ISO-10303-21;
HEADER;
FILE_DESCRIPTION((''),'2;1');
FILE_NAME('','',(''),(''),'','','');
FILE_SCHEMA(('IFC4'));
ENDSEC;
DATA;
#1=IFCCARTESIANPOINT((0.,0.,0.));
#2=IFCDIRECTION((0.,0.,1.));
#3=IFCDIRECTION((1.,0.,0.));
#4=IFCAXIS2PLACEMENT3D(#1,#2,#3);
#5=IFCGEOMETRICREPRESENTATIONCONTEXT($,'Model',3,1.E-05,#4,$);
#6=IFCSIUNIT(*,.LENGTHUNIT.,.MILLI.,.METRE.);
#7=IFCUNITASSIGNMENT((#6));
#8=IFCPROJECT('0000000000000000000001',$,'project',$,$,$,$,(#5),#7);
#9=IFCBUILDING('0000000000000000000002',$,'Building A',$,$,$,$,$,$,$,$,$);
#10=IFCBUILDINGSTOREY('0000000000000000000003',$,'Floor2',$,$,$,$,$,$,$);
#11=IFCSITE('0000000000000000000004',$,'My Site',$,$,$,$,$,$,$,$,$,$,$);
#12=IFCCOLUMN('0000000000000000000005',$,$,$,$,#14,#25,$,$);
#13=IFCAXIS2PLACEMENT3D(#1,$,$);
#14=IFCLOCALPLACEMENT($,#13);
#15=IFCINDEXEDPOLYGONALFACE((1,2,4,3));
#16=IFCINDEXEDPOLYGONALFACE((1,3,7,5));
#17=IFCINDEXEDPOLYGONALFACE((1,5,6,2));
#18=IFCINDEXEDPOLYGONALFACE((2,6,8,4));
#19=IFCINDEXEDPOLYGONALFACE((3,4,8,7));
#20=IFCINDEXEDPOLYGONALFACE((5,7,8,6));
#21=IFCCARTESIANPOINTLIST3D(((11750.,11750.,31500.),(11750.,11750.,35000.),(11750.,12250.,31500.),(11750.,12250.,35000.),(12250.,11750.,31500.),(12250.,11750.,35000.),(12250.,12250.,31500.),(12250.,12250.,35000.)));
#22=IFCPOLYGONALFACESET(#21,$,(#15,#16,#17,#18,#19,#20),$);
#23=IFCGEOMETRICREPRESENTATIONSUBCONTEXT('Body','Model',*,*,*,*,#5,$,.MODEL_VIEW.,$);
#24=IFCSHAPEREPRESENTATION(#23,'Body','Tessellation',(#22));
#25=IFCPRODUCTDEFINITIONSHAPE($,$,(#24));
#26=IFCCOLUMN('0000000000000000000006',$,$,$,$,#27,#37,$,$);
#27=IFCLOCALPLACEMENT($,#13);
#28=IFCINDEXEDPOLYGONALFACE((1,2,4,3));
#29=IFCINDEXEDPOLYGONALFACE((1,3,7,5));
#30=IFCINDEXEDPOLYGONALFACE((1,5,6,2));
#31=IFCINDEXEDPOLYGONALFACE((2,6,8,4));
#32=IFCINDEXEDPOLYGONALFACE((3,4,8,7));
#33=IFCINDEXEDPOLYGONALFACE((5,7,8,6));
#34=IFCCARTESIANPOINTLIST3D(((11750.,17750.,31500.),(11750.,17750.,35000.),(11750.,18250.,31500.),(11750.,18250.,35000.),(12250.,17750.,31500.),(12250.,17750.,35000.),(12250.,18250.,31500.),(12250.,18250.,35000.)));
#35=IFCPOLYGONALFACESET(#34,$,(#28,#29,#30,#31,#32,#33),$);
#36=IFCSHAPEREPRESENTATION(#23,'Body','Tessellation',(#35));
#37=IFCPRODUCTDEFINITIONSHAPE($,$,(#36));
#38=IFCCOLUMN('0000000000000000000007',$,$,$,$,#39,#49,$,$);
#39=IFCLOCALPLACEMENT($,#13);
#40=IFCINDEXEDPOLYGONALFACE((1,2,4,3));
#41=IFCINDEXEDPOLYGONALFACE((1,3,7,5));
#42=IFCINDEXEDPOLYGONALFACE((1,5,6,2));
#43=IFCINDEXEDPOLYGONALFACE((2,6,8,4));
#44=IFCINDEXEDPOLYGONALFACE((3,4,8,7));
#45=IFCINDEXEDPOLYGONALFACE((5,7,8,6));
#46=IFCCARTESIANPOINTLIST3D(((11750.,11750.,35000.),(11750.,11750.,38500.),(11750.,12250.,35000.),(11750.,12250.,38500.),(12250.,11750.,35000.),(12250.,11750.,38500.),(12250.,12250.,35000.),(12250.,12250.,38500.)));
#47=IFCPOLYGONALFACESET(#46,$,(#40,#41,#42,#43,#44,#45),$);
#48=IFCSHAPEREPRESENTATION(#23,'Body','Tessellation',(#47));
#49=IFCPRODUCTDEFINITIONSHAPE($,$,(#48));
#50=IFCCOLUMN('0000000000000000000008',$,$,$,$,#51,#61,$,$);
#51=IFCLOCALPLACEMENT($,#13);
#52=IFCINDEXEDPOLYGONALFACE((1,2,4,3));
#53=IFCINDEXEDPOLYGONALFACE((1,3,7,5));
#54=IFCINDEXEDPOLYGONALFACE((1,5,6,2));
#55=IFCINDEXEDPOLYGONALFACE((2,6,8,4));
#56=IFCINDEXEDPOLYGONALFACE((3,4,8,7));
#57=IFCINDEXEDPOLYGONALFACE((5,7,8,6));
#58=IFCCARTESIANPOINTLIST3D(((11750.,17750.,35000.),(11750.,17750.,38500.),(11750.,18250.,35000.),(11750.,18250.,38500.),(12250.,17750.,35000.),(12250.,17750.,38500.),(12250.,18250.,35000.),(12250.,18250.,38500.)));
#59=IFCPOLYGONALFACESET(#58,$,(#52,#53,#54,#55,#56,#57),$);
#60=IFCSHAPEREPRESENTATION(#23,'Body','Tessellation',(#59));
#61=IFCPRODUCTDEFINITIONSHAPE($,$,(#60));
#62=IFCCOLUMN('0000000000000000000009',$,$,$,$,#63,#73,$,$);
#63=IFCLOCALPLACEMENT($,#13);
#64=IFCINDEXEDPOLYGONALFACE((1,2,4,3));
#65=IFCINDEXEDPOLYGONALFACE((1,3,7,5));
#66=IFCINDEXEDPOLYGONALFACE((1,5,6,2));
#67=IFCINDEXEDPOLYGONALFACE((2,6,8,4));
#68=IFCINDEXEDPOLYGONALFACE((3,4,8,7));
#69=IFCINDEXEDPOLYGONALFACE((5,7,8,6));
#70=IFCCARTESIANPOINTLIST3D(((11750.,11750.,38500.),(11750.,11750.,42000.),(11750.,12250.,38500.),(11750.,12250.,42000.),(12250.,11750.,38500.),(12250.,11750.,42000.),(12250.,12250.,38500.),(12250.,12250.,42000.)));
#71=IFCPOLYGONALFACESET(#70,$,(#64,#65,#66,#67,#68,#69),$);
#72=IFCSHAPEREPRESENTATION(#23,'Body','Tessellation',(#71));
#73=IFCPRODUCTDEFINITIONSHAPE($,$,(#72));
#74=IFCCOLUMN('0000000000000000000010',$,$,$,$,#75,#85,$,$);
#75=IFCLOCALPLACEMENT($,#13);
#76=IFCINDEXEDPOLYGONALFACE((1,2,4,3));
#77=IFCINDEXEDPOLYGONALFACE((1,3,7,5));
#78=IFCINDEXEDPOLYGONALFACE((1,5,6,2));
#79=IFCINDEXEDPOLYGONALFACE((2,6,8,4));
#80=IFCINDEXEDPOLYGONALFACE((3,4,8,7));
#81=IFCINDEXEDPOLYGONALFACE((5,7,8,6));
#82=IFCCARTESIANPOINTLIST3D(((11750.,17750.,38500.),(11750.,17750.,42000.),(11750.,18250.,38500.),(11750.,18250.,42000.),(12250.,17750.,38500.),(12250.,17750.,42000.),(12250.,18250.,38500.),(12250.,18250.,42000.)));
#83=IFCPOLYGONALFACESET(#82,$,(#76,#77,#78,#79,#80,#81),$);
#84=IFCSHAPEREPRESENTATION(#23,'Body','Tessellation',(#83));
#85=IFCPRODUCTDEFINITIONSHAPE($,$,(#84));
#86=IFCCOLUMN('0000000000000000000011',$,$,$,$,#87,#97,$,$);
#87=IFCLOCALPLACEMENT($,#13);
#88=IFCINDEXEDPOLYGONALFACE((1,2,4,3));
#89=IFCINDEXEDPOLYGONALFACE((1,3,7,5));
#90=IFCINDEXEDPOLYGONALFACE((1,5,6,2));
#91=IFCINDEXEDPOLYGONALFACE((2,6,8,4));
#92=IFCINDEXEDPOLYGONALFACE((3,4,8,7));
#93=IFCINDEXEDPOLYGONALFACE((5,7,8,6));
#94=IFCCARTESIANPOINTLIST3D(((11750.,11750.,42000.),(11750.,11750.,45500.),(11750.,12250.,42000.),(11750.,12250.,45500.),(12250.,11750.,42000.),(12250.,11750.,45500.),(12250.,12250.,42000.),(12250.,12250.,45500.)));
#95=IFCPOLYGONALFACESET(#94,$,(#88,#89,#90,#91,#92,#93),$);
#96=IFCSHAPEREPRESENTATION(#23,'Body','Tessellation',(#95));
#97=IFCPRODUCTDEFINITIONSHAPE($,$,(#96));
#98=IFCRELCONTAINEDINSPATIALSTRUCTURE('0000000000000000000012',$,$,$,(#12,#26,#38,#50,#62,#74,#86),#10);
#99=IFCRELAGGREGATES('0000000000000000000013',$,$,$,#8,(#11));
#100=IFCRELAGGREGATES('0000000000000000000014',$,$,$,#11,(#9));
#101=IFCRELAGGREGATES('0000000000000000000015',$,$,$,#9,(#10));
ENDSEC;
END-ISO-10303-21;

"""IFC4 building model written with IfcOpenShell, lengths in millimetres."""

from ifc_helpers import new_model, si_unit, frame, origin_with_axes, place, context, subcontext, project, spatial, line, indexed_curve, outline, extrude, element, save


model = new_model("IFC4")

# Units and contexts
model_context = context("Model", 3, precision=1e-05, world=origin_with_axes())
body_context = subcontext(model_context, "Body", "Model", "MODEL_VIEW")
ifc_project = project(units=[si_unit("LENGTHUNIT", "METRE", prefix="MILLI")], contexts=[model_context])

# Site, building, storey
site = spatial("IfcSite", under=ifc_project, Name="My Site")
building = spatial("IfcBuilding", under=site, Name="Building A")
storey = spatial("IfcBuildingStorey", under=building, Name="Floor2")

# Columns
for number, where, z_axis, x_axis in (
    (1, (12000.0, 12000.0, 31500.0), (0.0, 0.0, 1.0), (1.0, 0.0, 0.0)),
    (2, (12000.0, 18000.0, 31500.0), (0.0, 0.0, 1.0), (1.0, 0.0, 0.0)),
    (3, (12000.0, 12000.0, 35000.0), (0.0, 0.0, 1.0), (1.0, 0.0, 0.0)),
    (4, (12000.0, 18000.0, 35000.0), (0.0, 0.0, 1.0), (1.0, 0.0, 0.0)),
    (5, (12000.0, 12000.0, 38500.0), (0.0, 0.0, 1.0), (1.0, 0.0, 0.0)),
    (6, (12000.0, 18000.0, 38500.0), (0.0, 0.0, 1.0), (1.0, 0.0, 0.0)),
    (7, (12000.0, 12000.0, 42000.0), (0.0, 0.0, 1.0), (1.0, 0.0, 0.0)),
):
    element("IfcColumn", number, at=place(None, frame(where, z_axis=z_axis, x_axis=x_axis)), inside=storey, context=body_context, shape_type="SweptSolid", body=[
        extrude(outline(indexed_curve([(-250.0, -250.0), (250.0, -250.0), (250.0, 250.0), (-250.0, 250.0)], segments=[line(1, 2, 3, 4, 1)])), origin_with_axes(), (0.0, 0.0, 1.0), 3500.0),
    ])

save(model, "model.ifc")
